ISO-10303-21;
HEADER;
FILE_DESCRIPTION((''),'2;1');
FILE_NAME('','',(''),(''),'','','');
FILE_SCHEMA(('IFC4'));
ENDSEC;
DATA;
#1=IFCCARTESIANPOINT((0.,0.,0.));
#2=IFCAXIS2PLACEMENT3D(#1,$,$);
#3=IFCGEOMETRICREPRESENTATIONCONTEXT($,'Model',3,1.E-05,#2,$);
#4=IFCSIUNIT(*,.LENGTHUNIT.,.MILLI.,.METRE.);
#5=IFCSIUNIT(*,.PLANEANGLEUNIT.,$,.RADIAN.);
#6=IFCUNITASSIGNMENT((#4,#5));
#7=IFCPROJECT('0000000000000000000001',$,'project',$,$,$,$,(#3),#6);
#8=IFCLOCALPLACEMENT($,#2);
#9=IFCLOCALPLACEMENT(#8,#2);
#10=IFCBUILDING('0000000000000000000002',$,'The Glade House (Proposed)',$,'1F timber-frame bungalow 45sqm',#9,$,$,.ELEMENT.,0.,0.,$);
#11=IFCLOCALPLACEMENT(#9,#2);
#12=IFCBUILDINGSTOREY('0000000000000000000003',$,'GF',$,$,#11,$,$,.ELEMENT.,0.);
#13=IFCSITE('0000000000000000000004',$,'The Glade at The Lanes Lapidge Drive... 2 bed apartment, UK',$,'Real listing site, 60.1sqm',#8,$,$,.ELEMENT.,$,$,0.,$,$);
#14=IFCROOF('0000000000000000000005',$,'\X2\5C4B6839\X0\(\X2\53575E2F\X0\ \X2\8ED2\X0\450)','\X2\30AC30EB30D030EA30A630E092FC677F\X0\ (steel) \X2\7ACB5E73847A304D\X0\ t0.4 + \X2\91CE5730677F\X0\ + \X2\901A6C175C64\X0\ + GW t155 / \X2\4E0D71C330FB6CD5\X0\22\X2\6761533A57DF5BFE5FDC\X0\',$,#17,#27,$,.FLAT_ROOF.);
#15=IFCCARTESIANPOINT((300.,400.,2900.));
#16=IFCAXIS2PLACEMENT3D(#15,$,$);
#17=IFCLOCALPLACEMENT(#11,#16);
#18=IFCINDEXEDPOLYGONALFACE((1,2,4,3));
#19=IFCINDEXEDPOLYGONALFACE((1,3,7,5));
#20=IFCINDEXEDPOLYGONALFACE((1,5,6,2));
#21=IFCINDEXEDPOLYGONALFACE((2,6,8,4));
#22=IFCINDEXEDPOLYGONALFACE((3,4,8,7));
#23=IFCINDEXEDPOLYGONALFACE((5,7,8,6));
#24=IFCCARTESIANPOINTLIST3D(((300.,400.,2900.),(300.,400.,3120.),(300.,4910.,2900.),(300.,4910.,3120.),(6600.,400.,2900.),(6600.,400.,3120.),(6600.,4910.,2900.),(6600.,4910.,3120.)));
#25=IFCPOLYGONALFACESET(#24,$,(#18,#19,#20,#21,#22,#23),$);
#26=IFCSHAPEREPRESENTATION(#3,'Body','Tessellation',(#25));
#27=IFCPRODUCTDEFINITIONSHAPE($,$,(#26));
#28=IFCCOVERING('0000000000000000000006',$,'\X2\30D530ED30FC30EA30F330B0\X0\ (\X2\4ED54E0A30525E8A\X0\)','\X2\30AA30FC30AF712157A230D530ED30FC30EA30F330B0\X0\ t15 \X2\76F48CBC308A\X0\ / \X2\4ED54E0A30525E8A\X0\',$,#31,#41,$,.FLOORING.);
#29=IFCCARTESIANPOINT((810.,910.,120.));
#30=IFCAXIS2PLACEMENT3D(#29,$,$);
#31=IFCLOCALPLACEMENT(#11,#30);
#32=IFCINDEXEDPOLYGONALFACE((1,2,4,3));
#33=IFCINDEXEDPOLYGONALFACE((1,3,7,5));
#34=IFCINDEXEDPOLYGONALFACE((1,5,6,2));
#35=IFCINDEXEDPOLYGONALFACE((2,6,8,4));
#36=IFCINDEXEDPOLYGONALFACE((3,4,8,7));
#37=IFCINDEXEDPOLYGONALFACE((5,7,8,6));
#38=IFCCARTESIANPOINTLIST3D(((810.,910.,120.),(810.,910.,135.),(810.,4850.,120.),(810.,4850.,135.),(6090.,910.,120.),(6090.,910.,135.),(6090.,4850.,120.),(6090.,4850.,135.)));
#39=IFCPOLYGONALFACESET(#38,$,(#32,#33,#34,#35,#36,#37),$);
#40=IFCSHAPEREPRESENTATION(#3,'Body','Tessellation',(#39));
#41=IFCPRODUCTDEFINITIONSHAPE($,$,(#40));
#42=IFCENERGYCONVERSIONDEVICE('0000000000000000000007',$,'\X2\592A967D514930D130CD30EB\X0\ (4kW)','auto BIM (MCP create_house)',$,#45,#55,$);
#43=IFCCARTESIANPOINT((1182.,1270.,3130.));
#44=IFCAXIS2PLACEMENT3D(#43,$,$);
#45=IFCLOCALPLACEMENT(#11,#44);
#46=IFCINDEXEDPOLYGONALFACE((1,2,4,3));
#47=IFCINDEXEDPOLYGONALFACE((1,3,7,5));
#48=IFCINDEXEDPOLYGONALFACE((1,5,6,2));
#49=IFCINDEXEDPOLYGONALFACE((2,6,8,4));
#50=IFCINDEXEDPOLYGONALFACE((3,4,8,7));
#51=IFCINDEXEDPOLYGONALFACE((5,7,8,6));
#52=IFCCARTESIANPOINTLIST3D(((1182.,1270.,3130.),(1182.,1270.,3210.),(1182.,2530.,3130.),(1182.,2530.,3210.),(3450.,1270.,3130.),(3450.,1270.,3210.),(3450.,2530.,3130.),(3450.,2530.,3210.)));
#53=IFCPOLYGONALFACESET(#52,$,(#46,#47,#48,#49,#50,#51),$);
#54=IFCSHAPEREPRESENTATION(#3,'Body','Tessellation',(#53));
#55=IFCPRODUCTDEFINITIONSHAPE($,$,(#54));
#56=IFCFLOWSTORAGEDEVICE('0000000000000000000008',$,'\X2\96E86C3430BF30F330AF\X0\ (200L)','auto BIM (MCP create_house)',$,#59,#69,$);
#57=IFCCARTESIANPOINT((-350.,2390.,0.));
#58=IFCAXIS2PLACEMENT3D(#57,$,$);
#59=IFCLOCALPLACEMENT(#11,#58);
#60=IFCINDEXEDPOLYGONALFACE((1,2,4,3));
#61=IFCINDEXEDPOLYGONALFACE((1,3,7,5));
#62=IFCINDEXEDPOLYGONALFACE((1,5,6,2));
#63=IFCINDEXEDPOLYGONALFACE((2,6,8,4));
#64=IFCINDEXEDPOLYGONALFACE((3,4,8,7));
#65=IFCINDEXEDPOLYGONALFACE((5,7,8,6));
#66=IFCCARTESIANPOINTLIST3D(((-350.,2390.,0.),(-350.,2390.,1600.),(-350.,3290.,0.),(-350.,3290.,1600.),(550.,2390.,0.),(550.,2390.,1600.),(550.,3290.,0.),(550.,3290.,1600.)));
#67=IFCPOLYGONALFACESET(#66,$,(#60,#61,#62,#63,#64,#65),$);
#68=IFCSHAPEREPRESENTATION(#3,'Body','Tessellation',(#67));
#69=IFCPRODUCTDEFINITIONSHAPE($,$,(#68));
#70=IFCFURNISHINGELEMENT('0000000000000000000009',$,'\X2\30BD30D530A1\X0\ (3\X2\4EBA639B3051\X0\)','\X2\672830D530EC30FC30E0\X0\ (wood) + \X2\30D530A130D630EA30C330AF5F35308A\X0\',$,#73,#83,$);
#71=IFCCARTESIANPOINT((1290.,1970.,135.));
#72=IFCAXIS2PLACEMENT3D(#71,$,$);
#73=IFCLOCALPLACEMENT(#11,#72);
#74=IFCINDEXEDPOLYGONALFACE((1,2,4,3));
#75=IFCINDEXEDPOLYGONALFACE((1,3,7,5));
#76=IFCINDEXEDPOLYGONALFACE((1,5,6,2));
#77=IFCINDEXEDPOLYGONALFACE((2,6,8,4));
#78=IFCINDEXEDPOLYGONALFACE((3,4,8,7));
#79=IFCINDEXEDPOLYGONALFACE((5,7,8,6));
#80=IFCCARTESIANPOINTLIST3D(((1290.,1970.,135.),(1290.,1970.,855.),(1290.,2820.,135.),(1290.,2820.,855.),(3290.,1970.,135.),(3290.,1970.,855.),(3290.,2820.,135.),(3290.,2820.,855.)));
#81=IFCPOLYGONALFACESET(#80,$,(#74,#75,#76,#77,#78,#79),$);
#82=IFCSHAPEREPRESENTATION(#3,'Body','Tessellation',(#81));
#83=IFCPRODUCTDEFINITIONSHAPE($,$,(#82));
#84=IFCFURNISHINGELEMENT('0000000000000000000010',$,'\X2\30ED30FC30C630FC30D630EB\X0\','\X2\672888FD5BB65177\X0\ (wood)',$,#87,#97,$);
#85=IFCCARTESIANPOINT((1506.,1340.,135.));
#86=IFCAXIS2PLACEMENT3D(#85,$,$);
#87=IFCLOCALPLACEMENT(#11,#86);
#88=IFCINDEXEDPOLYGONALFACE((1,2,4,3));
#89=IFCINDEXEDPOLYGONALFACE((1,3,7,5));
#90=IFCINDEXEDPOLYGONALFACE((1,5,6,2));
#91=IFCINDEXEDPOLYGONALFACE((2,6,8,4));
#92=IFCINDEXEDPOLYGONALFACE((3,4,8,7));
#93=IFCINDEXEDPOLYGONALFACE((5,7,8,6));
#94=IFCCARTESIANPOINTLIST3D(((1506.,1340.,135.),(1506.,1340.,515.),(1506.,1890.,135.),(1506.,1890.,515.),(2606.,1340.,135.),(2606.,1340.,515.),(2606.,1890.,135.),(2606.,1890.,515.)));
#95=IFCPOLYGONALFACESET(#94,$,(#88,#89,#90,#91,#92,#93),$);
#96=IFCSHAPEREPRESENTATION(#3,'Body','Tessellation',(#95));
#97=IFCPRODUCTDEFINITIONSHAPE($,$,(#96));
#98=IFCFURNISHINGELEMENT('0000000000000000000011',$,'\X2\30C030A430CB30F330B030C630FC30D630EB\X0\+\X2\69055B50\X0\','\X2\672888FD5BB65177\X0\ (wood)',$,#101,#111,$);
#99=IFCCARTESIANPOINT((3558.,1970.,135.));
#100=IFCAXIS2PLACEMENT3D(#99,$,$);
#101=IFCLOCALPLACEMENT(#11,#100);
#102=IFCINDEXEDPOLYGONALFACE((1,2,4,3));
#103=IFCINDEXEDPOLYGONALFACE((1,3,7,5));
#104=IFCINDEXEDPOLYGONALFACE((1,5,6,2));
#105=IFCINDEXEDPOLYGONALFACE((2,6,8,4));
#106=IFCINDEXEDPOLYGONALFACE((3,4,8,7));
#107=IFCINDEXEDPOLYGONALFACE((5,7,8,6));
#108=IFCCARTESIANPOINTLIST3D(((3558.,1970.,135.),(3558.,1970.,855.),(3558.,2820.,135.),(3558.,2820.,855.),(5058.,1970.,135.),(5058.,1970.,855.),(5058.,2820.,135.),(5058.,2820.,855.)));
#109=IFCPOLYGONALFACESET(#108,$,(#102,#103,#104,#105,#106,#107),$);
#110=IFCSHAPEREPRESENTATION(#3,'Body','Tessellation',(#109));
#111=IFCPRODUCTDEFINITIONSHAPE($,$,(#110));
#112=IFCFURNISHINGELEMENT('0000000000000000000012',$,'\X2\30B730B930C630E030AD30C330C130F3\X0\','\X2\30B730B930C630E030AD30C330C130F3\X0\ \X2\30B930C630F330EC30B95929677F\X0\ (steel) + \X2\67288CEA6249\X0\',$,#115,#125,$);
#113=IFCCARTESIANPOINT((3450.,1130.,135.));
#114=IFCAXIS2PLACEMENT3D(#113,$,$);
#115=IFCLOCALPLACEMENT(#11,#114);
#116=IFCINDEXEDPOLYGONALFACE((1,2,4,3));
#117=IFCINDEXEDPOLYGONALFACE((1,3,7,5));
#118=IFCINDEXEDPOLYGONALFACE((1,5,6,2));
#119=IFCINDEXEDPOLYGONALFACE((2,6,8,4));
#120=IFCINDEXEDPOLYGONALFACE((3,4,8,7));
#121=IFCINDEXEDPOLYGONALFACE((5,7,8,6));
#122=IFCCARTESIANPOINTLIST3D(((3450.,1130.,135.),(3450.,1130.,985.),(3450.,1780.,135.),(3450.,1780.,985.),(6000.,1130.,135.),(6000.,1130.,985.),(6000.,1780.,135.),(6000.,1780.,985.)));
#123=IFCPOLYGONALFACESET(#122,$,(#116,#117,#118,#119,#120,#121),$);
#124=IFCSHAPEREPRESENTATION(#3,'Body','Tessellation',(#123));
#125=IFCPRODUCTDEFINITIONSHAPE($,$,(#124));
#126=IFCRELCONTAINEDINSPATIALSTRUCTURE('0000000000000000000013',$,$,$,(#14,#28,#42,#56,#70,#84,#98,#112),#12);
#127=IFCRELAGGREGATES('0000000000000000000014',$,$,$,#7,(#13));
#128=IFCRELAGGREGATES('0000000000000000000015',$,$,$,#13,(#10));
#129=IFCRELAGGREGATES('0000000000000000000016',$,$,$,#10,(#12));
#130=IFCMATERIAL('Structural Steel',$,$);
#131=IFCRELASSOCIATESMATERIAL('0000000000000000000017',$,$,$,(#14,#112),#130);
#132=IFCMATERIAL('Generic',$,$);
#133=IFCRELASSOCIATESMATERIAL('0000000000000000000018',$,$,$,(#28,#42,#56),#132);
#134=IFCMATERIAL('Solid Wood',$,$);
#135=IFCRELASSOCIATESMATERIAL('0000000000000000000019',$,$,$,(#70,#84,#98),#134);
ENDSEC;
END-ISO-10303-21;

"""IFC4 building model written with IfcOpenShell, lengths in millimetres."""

from ifc_helpers import new_model, si_unit, frame, frame_2d, origin, place, context, project, spatial, rectangle, extrude, material, element, save


model = new_model("IFC4")

# Units and contexts
model_context = context("Model", 3, precision=1e-05, world=origin())
ifc_project = project(units=[si_unit("LENGTHUNIT", "METRE", prefix="MILLI"), si_unit("PLANEANGLEUNIT", "RADIAN")], contexts=[model_context])

# Site, building, storey
site_placement = place(None, origin())
site = spatial("IfcSite", under=ifc_project, at=site_placement, Name="The Glade at The Lanes Lapidge Drive... 2 bed apartment, UK", ObjectType="Real listing site, 60.1sqm", CompositionType="ELEMENT", RefElevation=0.0)
building_placement = place(site_placement, origin())
building = spatial("IfcBuilding", under=site, at=building_placement, Name="The Glade House (Proposed)", ObjectType="1F timber-frame bungalow 45sqm", CompositionType="ELEMENT", ElevationOfRefHeight=0.0, ElevationOfTerrain=0.0)
storey_placement = place(building_placement, origin())
storey = spatial("IfcBuildingStorey", under=building, at=storey_placement, Name="GF", CompositionType="ELEMENT", Elevation=0.0)

# Shared definitions
ifc_material_1 = material(Name="Solid Wood")
ifc_material_2 = material(Name="Generic")

# Roof
ifc_material_3 = material(Name="Structural Steel")
roof_placement = place(storey_placement, frame((300.0, 400.0, 2900.0)))
element("IfcRoof", 1, at=roof_placement, inside=storey, material=ifc_material_3, Name="屋根(南帯 軒450)", Description="ガルバリウム鋼板 (steel) 立平葺き t0.4 + 野地板 + 通気層 + GW t155 / 不燃・法22条区域対応", PredefinedType="FLAT_ROOF", context=model_context, shape_type="SweptSolid", body=[
    extrude(rectangle(XDim=6300.0, YDim=4510.0, at=frame_2d((3150.0, 2255.0))), frame((300.0, 400.0, 2900.0)), (0.0, 0.0, 1.0), 220.0),
])

# Covering
covering_placement = place(storey_placement, frame((810.0, 910.0, 120.0)))
element("IfcCovering", 2, at=covering_placement, inside=storey, material=ifc_material_2, Name="フローリング (仕上げ床)", Description="オーク無垢フローリング t15 直貼り / 仕上げ床", PredefinedType="FLOORING", context=model_context, shape_type="SweptSolid", body=[
    extrude(rectangle(XDim=5280.0, YDim=3940.0, at=frame_2d((2640.0, 1970.0))), frame((810.0, 910.0, 120.0)), (0.0, 0.0, 1.0), 15.0),
])

# Energy conversion device
energy_conversion_device_placement = place(storey_placement, frame((1182.0, 1270.0, 3130.0)))
element("IfcEnergyConversionDevice", 3, at=energy_conversion_device_placement, inside=storey, material=ifc_material_2, Name="太陽光パネル (4kW)", Description="auto BIM (MCP create_house)", context=model_context, shape_type="SweptSolid", body=[
    extrude(rectangle(XDim=2268.0, YDim=1260.0, at=frame_2d((1134.0, 630.0))), frame((1182.0, 1270.0, 3130.0)), (0.0, 0.0, 1.0), 80.0),
])

# Flow storage device
flow_storage_device_placement = place(storey_placement, frame((-350.0, 2390.0, 0.0)))
element("IfcFlowStorageDevice", 4, at=flow_storage_device_placement, inside=storey, material=ifc_material_2, Name="雨水タンク (200L)", Description="auto BIM (MCP create_house)", context=model_context, shape_type="SweptSolid", body=[
    extrude(rectangle(XDim=900.0, YDim=900.0, at=frame_2d((450.0, 450.0))), frame((-350.0, 2390.0, 0.0)), (0.0, 0.0, 1.0), 1600.0),
])

# Furnishing elements
furnishing_1_placement = place(storey_placement, frame((1290.0, 1970.0, 135.0)))
element("IfcFurnishingElement", 5, at=furnishing_1_placement, inside=storey, material=ifc_material_1, Name="ソファ (3人掛け)", Description="木フレーム (wood) + ファブリック張り", context=model_context, shape_type="SweptSolid", body=[
    extrude(rectangle(XDim=2000.0, YDim=850.0, at=frame_2d((1000.0, 425.0))), frame((1290.0, 1970.0, 135.0)), (0.0, 0.0, 1.0), 720.0),
])
furnishing_2_placement = place(storey_placement, frame((1506.0, 1340.0, 135.0)))
element("IfcFurnishingElement", 6, at=furnishing_2_placement, inside=storey, material=ifc_material_1, Name="ローテーブル", Description="木製家具 (wood)", context=model_context, shape_type="SweptSolid", body=[
    extrude(rectangle(XDim=1100.0, YDim=550.0, at=frame_2d((550.0, 275.0))), frame((1506.0, 1340.0, 135.0)), (0.0, 0.0, 1.0), 380.0),
])
furnishing_3_placement = place(storey_placement, frame((3558.0, 1970.0, 135.0)))
element("IfcFurnishingElement", 7, at=furnishing_3_placement, inside=storey, material=ifc_material_1, Name="ダイニングテーブル+椅子", Description="木製家具 (wood)", context=model_context, shape_type="SweptSolid", body=[
    extrude(rectangle(XDim=1500.0, YDim=850.0, at=frame_2d((750.0, 425.0))), frame((3558.0, 1970.0, 135.0)), (0.0, 0.0, 1.0), 720.0),
])
furnishing_4_placement = place(storey_placement, frame((3450.0, 1130.0, 135.0)))
element("IfcFurnishingElement", 8, at=furnishing_4_placement, inside=storey, material=ifc_material_3, Name="システムキッチン", Description="システムキッチン ステンレス天板 (steel) + 木質扉", context=model_context, shape_type="SweptSolid", body=[
    extrude(rectangle(XDim=2550.0, YDim=650.0, at=frame_2d((1275.0, 325.0))), frame((3450.0, 1130.0, 135.0)), (0.0, 0.0, 1.0), 850.0),
])

save(model, "model.ifc")
